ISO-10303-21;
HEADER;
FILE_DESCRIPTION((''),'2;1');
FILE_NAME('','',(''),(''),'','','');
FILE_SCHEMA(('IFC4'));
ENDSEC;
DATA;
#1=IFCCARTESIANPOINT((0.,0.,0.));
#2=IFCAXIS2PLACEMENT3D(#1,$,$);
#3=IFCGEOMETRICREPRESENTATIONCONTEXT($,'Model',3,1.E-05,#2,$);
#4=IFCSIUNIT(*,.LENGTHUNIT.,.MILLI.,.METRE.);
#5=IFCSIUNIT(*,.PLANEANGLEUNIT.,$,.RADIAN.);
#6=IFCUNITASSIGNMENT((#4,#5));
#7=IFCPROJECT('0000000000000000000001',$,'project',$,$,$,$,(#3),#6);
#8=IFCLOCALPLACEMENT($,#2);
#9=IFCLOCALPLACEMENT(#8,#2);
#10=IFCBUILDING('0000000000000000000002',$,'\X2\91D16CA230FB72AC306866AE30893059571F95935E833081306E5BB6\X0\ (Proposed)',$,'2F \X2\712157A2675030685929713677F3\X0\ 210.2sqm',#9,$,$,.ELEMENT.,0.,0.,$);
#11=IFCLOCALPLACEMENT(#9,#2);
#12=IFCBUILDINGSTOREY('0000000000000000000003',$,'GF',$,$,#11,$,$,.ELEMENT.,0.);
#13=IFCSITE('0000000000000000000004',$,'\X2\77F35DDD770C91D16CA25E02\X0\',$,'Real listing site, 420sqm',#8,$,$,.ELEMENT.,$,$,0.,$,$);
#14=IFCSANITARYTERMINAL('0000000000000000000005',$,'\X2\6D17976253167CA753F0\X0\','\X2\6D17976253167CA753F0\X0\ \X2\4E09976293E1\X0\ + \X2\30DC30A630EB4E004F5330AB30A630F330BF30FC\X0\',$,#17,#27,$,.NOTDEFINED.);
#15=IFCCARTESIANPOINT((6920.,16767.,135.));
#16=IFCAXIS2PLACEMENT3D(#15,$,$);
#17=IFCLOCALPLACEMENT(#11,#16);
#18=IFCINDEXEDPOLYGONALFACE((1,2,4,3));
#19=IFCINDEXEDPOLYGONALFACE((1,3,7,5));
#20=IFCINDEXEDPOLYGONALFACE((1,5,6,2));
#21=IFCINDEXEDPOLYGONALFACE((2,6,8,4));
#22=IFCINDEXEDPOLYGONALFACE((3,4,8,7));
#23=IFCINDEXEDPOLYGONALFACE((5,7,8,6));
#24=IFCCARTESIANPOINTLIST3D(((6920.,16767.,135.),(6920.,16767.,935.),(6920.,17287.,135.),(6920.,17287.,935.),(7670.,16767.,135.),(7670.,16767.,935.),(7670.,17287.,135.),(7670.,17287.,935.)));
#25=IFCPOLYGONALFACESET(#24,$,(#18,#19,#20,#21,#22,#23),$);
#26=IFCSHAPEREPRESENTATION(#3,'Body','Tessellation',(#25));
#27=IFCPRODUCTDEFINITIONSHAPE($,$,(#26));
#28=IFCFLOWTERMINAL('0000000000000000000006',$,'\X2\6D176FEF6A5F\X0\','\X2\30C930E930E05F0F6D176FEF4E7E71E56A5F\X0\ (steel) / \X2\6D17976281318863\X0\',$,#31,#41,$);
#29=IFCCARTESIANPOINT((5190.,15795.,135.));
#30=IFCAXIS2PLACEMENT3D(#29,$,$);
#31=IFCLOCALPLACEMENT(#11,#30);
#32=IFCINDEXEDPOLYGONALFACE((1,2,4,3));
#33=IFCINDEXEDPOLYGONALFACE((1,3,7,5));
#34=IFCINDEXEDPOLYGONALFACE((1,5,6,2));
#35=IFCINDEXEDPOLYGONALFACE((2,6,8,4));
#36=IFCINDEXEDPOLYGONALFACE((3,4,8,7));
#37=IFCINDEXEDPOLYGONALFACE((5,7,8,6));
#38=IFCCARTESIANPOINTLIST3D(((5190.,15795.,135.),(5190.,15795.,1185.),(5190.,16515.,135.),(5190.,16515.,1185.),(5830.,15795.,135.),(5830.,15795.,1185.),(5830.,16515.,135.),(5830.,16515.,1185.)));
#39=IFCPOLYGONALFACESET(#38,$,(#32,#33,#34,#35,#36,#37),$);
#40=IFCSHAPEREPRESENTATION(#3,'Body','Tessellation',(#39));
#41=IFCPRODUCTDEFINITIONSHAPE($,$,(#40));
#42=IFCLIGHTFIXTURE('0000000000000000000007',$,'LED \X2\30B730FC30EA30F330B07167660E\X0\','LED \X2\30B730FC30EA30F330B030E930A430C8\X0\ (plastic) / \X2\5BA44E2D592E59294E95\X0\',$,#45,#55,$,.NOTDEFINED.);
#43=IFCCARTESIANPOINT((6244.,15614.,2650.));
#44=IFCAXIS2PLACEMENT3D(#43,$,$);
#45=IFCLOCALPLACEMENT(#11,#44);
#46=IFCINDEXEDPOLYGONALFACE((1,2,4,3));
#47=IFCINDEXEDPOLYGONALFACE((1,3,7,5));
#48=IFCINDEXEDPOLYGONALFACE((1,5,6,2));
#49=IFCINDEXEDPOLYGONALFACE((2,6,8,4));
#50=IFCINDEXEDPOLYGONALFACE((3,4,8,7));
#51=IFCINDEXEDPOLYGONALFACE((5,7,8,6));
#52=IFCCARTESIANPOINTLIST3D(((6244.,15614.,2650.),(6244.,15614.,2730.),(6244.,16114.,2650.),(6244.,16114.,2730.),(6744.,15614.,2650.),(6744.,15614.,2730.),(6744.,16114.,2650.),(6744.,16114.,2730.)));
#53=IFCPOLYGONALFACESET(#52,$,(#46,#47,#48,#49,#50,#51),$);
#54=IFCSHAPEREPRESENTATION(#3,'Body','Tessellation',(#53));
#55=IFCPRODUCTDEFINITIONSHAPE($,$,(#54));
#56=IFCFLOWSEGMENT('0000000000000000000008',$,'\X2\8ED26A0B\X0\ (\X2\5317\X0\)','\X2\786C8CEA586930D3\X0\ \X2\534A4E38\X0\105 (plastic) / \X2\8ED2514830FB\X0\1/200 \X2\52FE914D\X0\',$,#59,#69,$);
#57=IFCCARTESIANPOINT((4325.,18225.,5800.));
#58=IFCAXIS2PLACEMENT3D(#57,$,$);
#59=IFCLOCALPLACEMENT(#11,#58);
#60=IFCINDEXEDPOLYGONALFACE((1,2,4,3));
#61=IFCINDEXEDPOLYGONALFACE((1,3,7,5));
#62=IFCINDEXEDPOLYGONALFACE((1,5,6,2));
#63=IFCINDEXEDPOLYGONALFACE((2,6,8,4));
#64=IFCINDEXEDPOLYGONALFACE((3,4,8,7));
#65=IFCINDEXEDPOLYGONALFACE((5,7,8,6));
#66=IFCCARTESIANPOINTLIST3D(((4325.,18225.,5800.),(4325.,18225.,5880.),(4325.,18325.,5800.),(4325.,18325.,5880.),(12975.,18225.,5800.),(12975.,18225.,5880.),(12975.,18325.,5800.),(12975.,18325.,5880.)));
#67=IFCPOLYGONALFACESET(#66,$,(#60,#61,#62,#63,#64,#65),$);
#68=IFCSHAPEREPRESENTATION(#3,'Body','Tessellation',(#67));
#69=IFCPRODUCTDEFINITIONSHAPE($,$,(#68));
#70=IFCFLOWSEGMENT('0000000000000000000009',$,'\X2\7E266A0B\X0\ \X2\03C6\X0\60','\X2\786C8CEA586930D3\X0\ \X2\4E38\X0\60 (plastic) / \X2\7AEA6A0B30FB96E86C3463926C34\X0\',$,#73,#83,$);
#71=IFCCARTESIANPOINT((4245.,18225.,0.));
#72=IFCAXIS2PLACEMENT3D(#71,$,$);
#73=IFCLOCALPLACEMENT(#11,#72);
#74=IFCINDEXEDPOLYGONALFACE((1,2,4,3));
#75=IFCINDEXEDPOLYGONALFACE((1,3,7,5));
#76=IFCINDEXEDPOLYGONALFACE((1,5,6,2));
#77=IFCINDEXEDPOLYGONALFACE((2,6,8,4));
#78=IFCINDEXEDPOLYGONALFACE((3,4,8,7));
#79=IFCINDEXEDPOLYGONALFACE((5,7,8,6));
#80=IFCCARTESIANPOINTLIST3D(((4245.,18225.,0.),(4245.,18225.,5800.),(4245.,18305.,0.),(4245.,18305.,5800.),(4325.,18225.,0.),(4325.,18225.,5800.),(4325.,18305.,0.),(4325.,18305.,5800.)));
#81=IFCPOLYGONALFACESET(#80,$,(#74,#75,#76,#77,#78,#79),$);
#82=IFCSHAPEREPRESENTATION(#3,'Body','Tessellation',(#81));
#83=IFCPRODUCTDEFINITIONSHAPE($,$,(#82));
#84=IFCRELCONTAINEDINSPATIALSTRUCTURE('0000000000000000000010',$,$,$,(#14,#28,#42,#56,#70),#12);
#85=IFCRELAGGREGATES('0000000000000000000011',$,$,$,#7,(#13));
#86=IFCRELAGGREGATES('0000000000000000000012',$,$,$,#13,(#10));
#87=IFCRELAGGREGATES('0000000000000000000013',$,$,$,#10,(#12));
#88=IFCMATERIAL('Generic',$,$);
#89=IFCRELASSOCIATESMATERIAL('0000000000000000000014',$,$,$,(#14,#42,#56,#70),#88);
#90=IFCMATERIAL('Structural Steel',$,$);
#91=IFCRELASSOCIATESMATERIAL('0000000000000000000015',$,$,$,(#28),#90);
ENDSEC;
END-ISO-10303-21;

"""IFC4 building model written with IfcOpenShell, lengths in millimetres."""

from ifc_helpers import new_model, si_unit, frame, frame_2d, origin, place, context, project, spatial, rectangle, extrude, material, element, save


model = new_model("IFC4")

# Units and contexts
model_context = context("Model", 3, precision=1e-05, world=origin())
ifc_project = project(units=[si_unit("LENGTHUNIT", "METRE", prefix="MILLI"), si_unit("PLANEANGLEUNIT", "RADIAN")], contexts=[model_context])

# Site, building, storey
site_placement = place(None, origin())
site = spatial("IfcSite", under=ifc_project, at=site_placement, Name="石川県金沢市", ObjectType="Real listing site, 420sqm", CompositionType="ELEMENT", RefElevation=0.0)
building_placement = place(site_placement, origin())
building = spatial("IfcBuilding", under=site, at=building_placement, Name="金沢・犬と暮らす土間広めの家 (Proposed)", ObjectType="2F 無垢材と天然石 210.2sqm", CompositionType="ELEMENT", ElevationOfRefHeight=0.0, ElevationOfTerrain=0.0)
storey_placement = place(building_placement, origin())
storey = spatial("IfcBuildingStorey", under=building, at=storey_placement, Name="GF", CompositionType="ELEMENT", Elevation=0.0)

# Sanitary terminal
ifc_material_1 = material(Name="Generic")
sanitary_terminal_placement = place(storey_placement, frame((6920.0, 16767.0, 135.0)))
element("IfcSanitaryTerminal", 1, at=sanitary_terminal_placement, inside=storey, material=ifc_material_1, Name="洗面化粧台", Description="洗面化粧台 三面鏡 + ボウル一体カウンター", PredefinedType="NOTDEFINED", context=model_context, shape_type="SweptSolid", body=[
    extrude(rectangle(XDim=750.0, YDim=520.0, at=frame_2d((375.0, 260.0))), frame((6920.0, 16767.0, 135.0)), (0.0, 0.0, 1.0), 800.0),
])

# Flow terminal
ifc_material_2 = material(Name="Structural Steel")
flow_terminal_placement = place(storey_placement, frame((5190.0, 15795.0, 135.0)))
element("IfcFlowTerminal", 2, at=flow_terminal_placement, inside=storey, material=ifc_material_2, Name="洗濯機", Description="ドラム式洗濯乾燥機 (steel) / 洗面脱衣", context=model_context, shape_type="SweptSolid", body=[
    extrude(rectangle(XDim=640.0, YDim=720.0, at=frame_2d((320.0, 360.0))), frame((5190.0, 15795.0, 135.0)), (0.0, 0.0, 1.0), 1050.0),
])

# Light fixture
light_fixture_placement = place(storey_placement, frame((6244.0, 15614.0, 2650.0)))
element("IfcLightFixture", 3, at=light_fixture_placement, inside=storey, material=ifc_material_1, Name="LED シーリング照明", Description="LED シーリングライト (plastic) / 室中央天井", PredefinedType="NOTDEFINED", context=model_context, shape_type="SweptSolid", body=[
    extrude(rectangle(XDim=500.0, YDim=500.0, at=frame_2d((250.0, 250.0))), frame((6244.0, 15614.0, 2650.0)), (0.0, 0.0, 1.0), 80.0),
])

# Flow segments
flow_segment_1_placement = place(storey_placement, frame((4325.0, 18225.0, 5800.0)))
element("IfcFlowSegment", 4, at=flow_segment_1_placement, inside=storey, material=ifc_material_1, Name="軒樋 (北)", Description="硬質塩ビ 半丸105 (plastic) / 軒先・1/200 勾配", context=model_context, shape_type="SweptSolid", body=[
    extrude(rectangle(XDim=8650.0, YDim=100.0, at=frame_2d((4325.0, 50.0))), frame((4325.0, 18225.0, 5800.0)), (0.0, 0.0, 1.0), 80.0),
])
flow_segment_2_placement = place(storey_placement, frame((4245.0, 18225.0, 0.0)))
element("IfcFlowSegment", 5, at=flow_segment_2_placement, inside=storey, material=ifc_material_1, Name="縦樋 φ60", Description="硬質塩ビ 丸60 (plastic) / 竪樋・雨水排水", context=model_context, shape_type="SweptSolid", body=[
    extrude(rectangle(XDim=80.0, YDim=80.0, at=frame_2d((40.0, 40.0))), frame((4245.0, 18225.0, 0.0)), (0.0, 0.0, 1.0), 5800.0),
])

save(model, "model.ifc")
